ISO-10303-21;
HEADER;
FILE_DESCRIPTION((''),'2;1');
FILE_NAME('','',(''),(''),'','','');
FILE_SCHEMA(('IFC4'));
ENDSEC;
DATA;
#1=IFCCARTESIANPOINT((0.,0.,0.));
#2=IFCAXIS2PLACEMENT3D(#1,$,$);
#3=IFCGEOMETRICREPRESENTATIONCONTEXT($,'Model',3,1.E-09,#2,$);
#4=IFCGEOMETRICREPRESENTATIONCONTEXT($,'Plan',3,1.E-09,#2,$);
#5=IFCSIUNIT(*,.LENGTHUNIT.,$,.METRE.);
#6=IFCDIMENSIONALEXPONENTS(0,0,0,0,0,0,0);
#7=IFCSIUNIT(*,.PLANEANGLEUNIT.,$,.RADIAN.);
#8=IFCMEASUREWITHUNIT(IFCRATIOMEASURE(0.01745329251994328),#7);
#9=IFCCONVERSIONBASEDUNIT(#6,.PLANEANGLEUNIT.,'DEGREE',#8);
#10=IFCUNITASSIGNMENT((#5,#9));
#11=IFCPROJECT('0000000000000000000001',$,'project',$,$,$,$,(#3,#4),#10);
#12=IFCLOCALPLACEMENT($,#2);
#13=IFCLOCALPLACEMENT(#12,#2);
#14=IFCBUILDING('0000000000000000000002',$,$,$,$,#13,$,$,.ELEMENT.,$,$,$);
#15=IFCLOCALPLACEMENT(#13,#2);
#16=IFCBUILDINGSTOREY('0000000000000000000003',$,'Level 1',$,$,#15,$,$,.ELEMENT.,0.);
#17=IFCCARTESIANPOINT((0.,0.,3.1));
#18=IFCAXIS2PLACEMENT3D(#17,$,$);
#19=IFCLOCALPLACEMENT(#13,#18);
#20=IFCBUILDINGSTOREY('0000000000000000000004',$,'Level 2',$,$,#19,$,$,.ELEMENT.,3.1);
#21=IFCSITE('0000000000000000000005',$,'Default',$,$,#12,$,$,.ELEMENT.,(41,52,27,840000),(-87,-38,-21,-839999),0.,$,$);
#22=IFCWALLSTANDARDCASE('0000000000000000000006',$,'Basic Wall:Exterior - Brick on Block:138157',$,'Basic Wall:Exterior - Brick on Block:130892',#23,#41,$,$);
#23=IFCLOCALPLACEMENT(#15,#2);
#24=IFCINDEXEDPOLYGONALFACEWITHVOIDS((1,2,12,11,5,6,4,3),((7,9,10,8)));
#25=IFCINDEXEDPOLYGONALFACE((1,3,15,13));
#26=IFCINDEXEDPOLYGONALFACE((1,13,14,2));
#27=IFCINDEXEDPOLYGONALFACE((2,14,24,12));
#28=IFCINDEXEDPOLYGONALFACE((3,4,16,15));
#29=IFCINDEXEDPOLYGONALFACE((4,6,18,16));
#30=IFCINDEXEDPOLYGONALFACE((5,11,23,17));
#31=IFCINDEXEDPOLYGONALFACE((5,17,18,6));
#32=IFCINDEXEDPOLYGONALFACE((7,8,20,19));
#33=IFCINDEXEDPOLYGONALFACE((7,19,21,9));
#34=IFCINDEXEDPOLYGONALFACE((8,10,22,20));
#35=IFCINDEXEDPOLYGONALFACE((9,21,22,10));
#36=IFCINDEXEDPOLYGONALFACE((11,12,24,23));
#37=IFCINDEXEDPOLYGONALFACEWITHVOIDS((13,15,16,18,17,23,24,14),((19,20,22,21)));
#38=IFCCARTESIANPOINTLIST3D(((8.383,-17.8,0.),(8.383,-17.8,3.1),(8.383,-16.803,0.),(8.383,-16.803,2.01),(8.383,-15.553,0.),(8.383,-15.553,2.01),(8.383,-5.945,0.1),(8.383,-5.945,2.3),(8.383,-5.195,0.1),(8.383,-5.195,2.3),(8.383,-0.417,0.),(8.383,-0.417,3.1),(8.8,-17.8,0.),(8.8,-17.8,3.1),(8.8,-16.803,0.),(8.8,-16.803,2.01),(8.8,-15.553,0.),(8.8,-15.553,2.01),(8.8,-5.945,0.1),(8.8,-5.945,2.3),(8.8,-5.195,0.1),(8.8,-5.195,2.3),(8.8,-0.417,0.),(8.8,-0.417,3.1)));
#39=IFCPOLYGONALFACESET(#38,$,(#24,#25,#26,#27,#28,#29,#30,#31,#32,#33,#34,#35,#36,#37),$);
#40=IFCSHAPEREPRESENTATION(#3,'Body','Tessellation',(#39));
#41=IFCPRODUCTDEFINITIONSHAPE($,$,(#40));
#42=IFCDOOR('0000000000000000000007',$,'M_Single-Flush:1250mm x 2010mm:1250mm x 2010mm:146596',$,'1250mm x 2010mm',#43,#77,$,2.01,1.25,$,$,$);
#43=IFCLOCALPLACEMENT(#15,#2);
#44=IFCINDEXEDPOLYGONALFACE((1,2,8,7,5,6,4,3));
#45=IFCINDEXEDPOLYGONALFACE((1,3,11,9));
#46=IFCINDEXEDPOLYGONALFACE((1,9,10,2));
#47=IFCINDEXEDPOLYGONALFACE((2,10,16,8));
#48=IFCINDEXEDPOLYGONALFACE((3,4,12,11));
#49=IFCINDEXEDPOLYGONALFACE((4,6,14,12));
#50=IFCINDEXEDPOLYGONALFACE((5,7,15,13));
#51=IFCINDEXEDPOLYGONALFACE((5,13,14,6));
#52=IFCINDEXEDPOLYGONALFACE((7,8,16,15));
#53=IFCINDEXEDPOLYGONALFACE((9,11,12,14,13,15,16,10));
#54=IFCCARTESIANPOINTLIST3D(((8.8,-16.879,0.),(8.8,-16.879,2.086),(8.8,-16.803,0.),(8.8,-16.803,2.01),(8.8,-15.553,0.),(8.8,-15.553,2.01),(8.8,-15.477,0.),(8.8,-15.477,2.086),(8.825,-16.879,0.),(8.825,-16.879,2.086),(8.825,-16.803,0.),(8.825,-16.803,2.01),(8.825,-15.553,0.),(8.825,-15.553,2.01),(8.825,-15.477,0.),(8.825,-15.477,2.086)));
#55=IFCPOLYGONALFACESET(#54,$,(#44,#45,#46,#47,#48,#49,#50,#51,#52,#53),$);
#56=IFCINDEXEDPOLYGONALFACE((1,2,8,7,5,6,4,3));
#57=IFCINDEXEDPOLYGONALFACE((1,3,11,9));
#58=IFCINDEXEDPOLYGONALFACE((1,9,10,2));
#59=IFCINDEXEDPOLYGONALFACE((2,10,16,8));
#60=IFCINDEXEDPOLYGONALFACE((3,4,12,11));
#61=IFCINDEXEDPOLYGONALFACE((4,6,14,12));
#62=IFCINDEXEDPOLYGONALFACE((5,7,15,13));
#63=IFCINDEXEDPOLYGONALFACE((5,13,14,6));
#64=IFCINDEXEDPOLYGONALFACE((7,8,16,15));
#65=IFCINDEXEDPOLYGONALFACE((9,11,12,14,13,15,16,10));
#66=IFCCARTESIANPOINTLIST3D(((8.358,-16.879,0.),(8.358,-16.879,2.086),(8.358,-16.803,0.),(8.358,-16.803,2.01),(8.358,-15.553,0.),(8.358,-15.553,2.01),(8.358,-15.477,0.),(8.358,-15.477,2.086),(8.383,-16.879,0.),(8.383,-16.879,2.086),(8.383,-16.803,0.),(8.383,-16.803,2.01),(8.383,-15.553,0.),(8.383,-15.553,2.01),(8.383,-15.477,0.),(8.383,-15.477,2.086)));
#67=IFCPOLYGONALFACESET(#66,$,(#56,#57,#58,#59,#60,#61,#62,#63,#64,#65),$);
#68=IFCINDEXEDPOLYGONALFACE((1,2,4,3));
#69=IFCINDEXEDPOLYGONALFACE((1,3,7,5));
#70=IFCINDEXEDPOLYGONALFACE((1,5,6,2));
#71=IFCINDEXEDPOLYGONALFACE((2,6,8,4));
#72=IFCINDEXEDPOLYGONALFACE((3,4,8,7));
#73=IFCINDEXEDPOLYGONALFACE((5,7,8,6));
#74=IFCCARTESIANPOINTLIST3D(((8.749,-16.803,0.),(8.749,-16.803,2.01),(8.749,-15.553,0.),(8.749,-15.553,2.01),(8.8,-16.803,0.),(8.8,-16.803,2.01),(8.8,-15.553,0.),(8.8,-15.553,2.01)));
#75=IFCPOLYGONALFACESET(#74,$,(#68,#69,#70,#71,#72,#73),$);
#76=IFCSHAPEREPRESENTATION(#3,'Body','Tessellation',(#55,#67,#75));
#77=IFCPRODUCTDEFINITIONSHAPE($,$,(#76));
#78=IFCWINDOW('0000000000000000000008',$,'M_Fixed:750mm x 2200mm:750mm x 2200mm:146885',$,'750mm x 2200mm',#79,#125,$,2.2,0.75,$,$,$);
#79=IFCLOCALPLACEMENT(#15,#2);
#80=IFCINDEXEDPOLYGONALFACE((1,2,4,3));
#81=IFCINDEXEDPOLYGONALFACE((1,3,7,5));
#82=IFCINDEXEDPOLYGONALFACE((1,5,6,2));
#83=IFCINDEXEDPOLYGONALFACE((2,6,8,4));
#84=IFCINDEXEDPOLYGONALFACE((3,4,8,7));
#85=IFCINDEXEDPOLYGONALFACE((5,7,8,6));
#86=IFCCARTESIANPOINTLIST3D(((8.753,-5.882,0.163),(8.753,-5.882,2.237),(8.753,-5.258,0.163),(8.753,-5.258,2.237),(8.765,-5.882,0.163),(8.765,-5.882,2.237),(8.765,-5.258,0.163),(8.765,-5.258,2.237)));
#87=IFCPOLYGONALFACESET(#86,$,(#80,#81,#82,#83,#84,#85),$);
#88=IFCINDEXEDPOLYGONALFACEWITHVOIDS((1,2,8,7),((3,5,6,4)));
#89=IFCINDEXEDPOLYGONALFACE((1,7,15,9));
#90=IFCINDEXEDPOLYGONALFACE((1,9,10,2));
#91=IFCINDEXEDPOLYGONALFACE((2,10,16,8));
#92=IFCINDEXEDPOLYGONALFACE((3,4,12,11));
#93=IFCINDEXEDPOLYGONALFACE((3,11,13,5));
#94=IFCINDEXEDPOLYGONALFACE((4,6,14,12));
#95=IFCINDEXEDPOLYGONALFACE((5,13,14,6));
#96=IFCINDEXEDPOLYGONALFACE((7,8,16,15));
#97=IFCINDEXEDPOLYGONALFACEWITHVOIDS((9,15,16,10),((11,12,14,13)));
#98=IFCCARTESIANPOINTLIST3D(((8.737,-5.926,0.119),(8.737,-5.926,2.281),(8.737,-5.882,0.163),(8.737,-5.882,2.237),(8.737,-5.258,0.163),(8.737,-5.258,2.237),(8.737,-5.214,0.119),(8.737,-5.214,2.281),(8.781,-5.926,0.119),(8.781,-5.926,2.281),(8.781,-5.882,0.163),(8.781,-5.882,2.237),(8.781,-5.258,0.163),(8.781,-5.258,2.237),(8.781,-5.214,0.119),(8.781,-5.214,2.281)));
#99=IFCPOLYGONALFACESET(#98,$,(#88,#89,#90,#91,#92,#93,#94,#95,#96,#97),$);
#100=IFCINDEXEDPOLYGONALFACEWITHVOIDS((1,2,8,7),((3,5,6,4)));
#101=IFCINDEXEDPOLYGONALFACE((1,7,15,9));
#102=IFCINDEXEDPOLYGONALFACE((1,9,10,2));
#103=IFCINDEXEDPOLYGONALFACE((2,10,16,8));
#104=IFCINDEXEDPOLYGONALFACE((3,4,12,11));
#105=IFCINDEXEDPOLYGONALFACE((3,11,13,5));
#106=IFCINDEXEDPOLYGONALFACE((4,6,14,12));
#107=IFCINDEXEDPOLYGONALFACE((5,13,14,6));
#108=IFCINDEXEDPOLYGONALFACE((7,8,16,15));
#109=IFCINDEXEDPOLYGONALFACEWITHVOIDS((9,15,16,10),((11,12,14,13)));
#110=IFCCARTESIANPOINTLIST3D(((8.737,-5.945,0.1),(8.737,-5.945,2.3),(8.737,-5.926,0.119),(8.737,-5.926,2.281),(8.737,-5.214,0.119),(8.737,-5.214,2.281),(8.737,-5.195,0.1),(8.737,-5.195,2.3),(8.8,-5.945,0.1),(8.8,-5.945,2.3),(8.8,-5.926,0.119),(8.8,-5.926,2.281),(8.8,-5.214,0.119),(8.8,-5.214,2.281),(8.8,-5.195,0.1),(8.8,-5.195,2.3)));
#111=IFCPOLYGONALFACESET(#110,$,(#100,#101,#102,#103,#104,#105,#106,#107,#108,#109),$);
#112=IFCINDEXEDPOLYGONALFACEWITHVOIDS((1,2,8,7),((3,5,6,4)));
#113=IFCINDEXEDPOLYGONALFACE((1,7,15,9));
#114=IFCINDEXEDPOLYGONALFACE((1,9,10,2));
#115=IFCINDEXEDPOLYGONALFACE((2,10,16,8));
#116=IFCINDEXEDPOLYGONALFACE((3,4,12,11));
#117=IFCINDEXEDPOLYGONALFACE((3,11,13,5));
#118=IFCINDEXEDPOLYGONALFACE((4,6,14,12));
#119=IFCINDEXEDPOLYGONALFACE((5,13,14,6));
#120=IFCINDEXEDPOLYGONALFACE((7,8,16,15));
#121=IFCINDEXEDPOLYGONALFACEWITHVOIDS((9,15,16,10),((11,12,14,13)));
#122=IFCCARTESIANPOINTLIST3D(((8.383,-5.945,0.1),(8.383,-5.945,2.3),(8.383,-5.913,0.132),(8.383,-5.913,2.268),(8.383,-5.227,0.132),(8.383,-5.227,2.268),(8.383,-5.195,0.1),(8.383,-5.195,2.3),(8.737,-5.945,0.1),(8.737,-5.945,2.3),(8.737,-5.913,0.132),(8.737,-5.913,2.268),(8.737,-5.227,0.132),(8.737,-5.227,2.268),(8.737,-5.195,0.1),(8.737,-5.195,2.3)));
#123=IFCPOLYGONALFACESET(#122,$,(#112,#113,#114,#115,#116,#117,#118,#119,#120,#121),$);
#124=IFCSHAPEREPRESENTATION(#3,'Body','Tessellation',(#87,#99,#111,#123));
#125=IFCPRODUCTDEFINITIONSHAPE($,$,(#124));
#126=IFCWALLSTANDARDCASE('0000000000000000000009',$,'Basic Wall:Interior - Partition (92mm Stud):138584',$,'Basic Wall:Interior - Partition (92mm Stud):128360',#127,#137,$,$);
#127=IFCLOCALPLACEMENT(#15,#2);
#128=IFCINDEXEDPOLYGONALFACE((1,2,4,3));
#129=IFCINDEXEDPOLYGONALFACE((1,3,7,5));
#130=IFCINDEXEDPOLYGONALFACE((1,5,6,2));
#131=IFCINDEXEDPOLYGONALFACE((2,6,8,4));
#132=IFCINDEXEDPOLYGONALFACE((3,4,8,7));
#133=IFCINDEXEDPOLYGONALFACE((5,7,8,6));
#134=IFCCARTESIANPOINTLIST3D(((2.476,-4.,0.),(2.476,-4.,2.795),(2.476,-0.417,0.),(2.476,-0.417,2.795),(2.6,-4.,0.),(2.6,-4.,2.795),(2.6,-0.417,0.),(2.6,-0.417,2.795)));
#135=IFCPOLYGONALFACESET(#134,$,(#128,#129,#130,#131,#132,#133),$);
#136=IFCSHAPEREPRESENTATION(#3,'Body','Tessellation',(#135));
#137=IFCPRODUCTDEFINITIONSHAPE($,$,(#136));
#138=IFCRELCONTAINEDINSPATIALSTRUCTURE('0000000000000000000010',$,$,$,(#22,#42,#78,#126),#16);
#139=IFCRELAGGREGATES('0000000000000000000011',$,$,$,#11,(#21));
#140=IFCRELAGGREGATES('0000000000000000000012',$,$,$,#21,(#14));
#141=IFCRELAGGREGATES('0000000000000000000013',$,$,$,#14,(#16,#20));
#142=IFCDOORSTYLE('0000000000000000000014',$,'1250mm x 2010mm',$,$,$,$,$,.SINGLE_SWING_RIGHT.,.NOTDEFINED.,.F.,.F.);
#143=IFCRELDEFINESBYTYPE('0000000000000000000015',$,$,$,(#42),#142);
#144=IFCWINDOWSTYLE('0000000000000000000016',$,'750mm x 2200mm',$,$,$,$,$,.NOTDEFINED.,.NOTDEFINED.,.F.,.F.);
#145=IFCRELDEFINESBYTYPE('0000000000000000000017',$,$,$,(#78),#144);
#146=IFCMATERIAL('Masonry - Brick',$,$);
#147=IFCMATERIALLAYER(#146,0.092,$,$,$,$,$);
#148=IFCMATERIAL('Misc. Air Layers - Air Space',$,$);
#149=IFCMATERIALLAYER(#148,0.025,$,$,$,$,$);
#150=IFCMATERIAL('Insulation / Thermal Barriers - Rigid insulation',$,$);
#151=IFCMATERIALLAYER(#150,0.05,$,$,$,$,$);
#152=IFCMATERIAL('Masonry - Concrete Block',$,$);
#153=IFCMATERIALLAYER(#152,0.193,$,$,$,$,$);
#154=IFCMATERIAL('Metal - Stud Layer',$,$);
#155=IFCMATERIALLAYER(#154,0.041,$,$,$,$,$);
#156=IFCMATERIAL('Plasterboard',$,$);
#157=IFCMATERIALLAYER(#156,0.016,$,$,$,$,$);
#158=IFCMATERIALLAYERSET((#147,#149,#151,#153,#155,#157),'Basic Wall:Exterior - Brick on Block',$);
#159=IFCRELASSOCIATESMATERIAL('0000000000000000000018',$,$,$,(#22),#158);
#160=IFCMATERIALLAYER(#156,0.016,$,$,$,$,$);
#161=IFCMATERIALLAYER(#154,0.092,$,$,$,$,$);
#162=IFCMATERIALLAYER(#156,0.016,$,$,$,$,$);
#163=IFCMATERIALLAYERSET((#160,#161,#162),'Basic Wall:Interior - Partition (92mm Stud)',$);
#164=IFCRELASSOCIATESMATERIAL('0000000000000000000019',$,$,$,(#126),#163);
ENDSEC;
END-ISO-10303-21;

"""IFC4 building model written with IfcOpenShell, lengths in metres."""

from ifc_helpers import new_model, entity, si_unit, converted_unit, frame, frame_2d, origin, origin_2d_with_axis, place, context, project, spatial, polyline, rectangle, outline, extrude, source, transform, mapped, material, layer, layer_set, layer_usage, type_object, type_shapes, element, fill, save


model = new_model("IFC4")

# Units and contexts
model_context = context("Model", 3, precision=1e-09, world=origin())
plan_context = context("Plan", 3, precision=1e-09, world=origin())
ifc_project = project(units=[si_unit("LENGTHUNIT", "METRE"), converted_unit("PLANEANGLEUNIT", "DEGREE", entity("IfcRatioMeasure", 0.01745329251994328), si_unit("PLANEANGLEUNIT", "RADIAN"), dimensions=[0, 0, 0, 0, 0, 0, 0])], contexts=[model_context, plan_context])

# Site, building, storey
site_placement = place(None, origin())
site = spatial("IfcSite", under=ifc_project, at=site_placement, Name="Default", CompositionType="ELEMENT", RefLatitude=(41, 52, 27, 840000), RefLongitude=(-87, -38, -21, -839999), RefElevation=0.0)
building_placement = place(site_placement, origin())
building = spatial("IfcBuilding", under=site, at=building_placement, CompositionType="ELEMENT")
storey_1_placement = place(building_placement, origin())
storey_1 = spatial("IfcBuildingStorey", under=building, at=storey_1_placement, Name="Level 1", CompositionType="ELEMENT", Elevation=0.0)

# Shared definitions
ifc_material_1 = material(Name="Masonry - Brick")
ifc_layer_1 = layer(ifc_material_1, 0.092)
ifc_material_2 = material(Name="Misc. Air Layers - Air Space")
ifc_layer_2 = layer(ifc_material_2, 0.025)
ifc_material_3 = material(Name="Insulation / Thermal Barriers - Rigid insulation")
ifc_layer_3 = layer(ifc_material_3, 0.05)
ifc_material_4 = material(Name="Masonry - Concrete Block")
ifc_layer_4 = layer(ifc_material_4, 0.193)
ifc_material_5 = material(Name="Metal - Stud Layer")
ifc_layer_5 = layer(ifc_material_5, 0.041)
ifc_material_6 = material(Name="Plasterboard")
ifc_layer_6 = layer(ifc_material_6, 0.016)
ifc_layer_set_1 = layer_set([ifc_layer_1, ifc_layer_2, ifc_layer_3, ifc_layer_4, ifc_layer_5, ifc_layer_6], Name="Basic Wall:Exterior - Brick on Block")

# Wall, openings, door, window
ifc_layer_usage_1 = layer_usage(ifc_layer_set_1, "AXIS2", "NEGATIVE", 0.2085)
wall_1_placement = place(storey_1_placement, frame((8.5915, -0.417, 0.0), z_axis=(0.0, 0.0, 1.0), x_axis=(0.0, -1.0, 0.0)))
wall_1 = element("IfcWallStandardCase", 1, at=wall_1_placement, inside=storey_1, material=ifc_layer_usage_1, Name="Basic Wall:Exterior - Brick on Block:138157", ObjectType="Basic Wall:Exterior - Brick on Block:130892", context=model_context, shape_type="SweptSolid", body=[
    extrude(rectangle(XDim=17.383, YDim=0.417, at=frame_2d((8.6915, 0.0), x_axis=(-1.0, 0.0))), origin(), (0.0, 0.0, 1.0), 3.1),
])
opening_1_placement = place(wall_1_placement, frame((15.136, -0.2085, 0.0)))
opening_1 = element("IfcOpeningElement", 2, at=opening_1_placement, cuts=wall_1, ObjectType="Opening", context=model_context, shape_type="SweptSolid", body=[
    extrude(rectangle(XDim=1.25, YDim=2.01, at=frame_2d((1.005, 0.625), x_axis=(0.0, 1.0))), frame((0.0, 0.0, 0.0), z_axis=(0.0, 1.0, 0.0), x_axis=(0.0, 0.0, 1.0)), (0.0, 0.0, 1.0), 0.417),
])
opening_2_placement = place(wall_1_placement, frame((4.778, -0.2085, 0.1)))
opening_2 = element("IfcOpeningElement", 3, at=opening_2_placement, cuts=wall_1, ObjectType="Opening", context=model_context, shape_type="SweptSolid", body=[
    extrude(rectangle(XDim=2.2, YDim=0.75, at=frame_2d((1.1, 0.375), x_axis=(1.0, 0.0))), frame((0.0, 0.0, 0.0), z_axis=(0.0, 1.0, 0.0), x_axis=(0.0, 0.0, 1.0)), (0.0, 0.0, 1.0), 0.417),
])
door_style_1 = type_object("IfcDoorStyle", Name="1250mm x 2010mm", ConstructionType="NOTDEFINED", OperationType="SINGLE_SWING_RIGHT", ParameterTakesPrecedence=False, Sizeable=False)
shared_shape_1 = source(origin(), model_context, "Body", "SweptSolid", [
    extrude(outline(polyline([(-0.701, -1.062), (0.701, -1.062), (0.701, 1.024), (0.625, 1.024), (0.625, -0.986), (-0.625, -0.986), (-0.625, 1.024), (-0.701, 1.024), (-0.701, -1.062)])), frame((0.625, 0.417, 1.024), z_axis=(0.0, 1.0, 0.0), x_axis=(1.0, 0.0, 0.0)), (0.0, 0.0, 1.0), 0.025),
    extrude(outline(polyline([(-1.062, -0.701), (1.024, -0.701), (1.024, -0.625), (-0.986, -0.625), (-0.986, 0.625), (1.024, 0.625), (1.024, 0.701), (-1.062, 0.701), (-1.062, -0.701)])), frame((0.625, -0.025, 1.024), z_axis=(0.0, 1.0, 0.0), x_axis=(0.0, 0.0, -1.0)), (0.0, 0.0, 1.0), 0.025),
    extrude(rectangle(XDim=0.051, YDim=1.25, at=origin_2d_with_axis()), frame((0.625, 0.3915, 0.0), z_axis=(0.0, 0.0, 1.0), x_axis=(0.0, 1.0, 0.0)), (0.0, 0.0, 1.0), 2.01),
])
type_shapes(door_style_1, [shared_shape_1])
door_1_placement = place(opening_1_placement, origin())
door_1 = element("IfcDoor", 4, at=door_1_placement, inside=storey_1, type_object=door_style_1, Name="M_Single-Flush:1250mm x 2010mm:1250mm x 2010mm:146596", ObjectType="1250mm x 2010mm", OverallHeight=2.01, OverallWidth=1.25, context=model_context, shape_type="MappedRepresentation", body=[
    mapped(shared_shape_1, transform((0.0, 0.0, 0.0), scale=1.0)),
])
fill(opening_1, door_1)
window_style_1 = type_object("IfcWindowStyle", Name="750mm x 2200mm", ConstructionType="NOTDEFINED", OperationType="NOTDEFINED", ParameterTakesPrecedence=False, Sizeable=False)
shared_shape_2 = source(origin(), model_context, "Body", "SweptSolid", [
    extrude(rectangle(XDim=0.012, YDim=0.624, at=origin_2d_with_axis()), frame((0.375, 0.376, 0.063), z_axis=(0.0, 0.0, 1.0), x_axis=(0.0, -1.0, 0.0)), (0.0, 0.0, 1.0), 2.074),
    extrude(outline(polyline([(-0.356, -1.081), (0.356, -1.081), (0.356, 1.081), (-0.356, 1.081), (-0.356, -1.081)]), holes=[polyline([(-0.312, -1.037), (-0.312, 1.037), (0.312, 1.037), (0.312, -1.037), (-0.312, -1.037)])]), frame((0.375, 0.354, 1.1), z_axis=(0.0, 1.0, 0.0), x_axis=(1.0, 0.0, 0.0)), (0.0, 0.0, 1.0), 0.044),
    extrude(outline(polyline([(-0.375, -1.1), (0.375, -1.1), (0.375, 1.1), (-0.375, 1.1), (-0.375, -1.1)]), holes=[polyline([(-0.356, -1.081), (-0.356, 1.081), (0.356, 1.081), (0.356, -1.081), (-0.356, -1.081)])]), frame((0.375, 0.354, 1.1), z_axis=(0.0, 1.0, 0.0), x_axis=(1.0, 0.0, 0.0)), (0.0, 0.0, 1.0), 0.063),
    extrude(outline(polyline([(-0.375, -1.1), (0.375, -1.1), (0.375, 1.1), (-0.375, 1.1), (-0.375, -1.1)]), holes=[polyline([(-0.343, -1.068), (-0.343, 1.068), (0.343, 1.068), (0.343, -1.068), (-0.343, -1.068)])]), frame((0.375, 0.0, 1.1), z_axis=(0.0, 1.0, 0.0), x_axis=(1.0, 0.0, 0.0)), (0.0, 0.0, 1.0), 0.354),
])
type_shapes(window_style_1, [shared_shape_2])
window_1_placement = place(opening_2_placement, origin())
window_1 = element("IfcWindow", 5, at=window_1_placement, inside=storey_1, type_object=window_style_1, Name="M_Fixed:750mm x 2200mm:750mm x 2200mm:146885", ObjectType="750mm x 2200mm", OverallHeight=2.2, OverallWidth=0.75, context=model_context, shape_type="MappedRepresentation", body=[
    mapped(shared_shape_2, transform((0.0, 0.0, 0.0), scale=1.0)),
])
fill(opening_2, window_1)

# Wall
ifc_layer_7 = layer(ifc_material_6, 0.016)
ifc_layer_8 = layer(ifc_material_5, 0.092)
ifc_layer_9 = layer(ifc_material_6, 0.016)
ifc_layer_set_2 = layer_set([ifc_layer_7, ifc_layer_8, ifc_layer_9], Name="Basic Wall:Interior - Partition (92mm Stud)")
ifc_layer_usage_2 = layer_usage(ifc_layer_set_2, "AXIS2", "NEGATIVE", 0.062)
wall_2_placement = place(storey_1_placement, frame((2.538, -0.417, 0.0), z_axis=(0.0, 0.0, 1.0), x_axis=(0.0, -1.0, 0.0)))
element("IfcWallStandardCase", 6, at=wall_2_placement, inside=storey_1, material=ifc_layer_usage_2, Name="Basic Wall:Interior - Partition (92mm Stud):138584", ObjectType="Basic Wall:Interior - Partition (92mm Stud):128360", context=model_context, shape_type="SweptSolid", body=[
    extrude(rectangle(XDim=3.583, YDim=0.124, at=frame_2d((1.7915, 0.0), x_axis=(-1.0, 0.0))), origin(), (0.0, 0.0, 1.0), 2.795),
])

# Shared definitions
storey_2_placement = place(building_placement, frame((0.0, 0.0, 3.1)))
storey_2 = spatial("IfcBuildingStorey", under=building, at=storey_2_placement, Name="Level 2", CompositionType="ELEMENT", Elevation=3.1)

save(model, "model.ifc")
